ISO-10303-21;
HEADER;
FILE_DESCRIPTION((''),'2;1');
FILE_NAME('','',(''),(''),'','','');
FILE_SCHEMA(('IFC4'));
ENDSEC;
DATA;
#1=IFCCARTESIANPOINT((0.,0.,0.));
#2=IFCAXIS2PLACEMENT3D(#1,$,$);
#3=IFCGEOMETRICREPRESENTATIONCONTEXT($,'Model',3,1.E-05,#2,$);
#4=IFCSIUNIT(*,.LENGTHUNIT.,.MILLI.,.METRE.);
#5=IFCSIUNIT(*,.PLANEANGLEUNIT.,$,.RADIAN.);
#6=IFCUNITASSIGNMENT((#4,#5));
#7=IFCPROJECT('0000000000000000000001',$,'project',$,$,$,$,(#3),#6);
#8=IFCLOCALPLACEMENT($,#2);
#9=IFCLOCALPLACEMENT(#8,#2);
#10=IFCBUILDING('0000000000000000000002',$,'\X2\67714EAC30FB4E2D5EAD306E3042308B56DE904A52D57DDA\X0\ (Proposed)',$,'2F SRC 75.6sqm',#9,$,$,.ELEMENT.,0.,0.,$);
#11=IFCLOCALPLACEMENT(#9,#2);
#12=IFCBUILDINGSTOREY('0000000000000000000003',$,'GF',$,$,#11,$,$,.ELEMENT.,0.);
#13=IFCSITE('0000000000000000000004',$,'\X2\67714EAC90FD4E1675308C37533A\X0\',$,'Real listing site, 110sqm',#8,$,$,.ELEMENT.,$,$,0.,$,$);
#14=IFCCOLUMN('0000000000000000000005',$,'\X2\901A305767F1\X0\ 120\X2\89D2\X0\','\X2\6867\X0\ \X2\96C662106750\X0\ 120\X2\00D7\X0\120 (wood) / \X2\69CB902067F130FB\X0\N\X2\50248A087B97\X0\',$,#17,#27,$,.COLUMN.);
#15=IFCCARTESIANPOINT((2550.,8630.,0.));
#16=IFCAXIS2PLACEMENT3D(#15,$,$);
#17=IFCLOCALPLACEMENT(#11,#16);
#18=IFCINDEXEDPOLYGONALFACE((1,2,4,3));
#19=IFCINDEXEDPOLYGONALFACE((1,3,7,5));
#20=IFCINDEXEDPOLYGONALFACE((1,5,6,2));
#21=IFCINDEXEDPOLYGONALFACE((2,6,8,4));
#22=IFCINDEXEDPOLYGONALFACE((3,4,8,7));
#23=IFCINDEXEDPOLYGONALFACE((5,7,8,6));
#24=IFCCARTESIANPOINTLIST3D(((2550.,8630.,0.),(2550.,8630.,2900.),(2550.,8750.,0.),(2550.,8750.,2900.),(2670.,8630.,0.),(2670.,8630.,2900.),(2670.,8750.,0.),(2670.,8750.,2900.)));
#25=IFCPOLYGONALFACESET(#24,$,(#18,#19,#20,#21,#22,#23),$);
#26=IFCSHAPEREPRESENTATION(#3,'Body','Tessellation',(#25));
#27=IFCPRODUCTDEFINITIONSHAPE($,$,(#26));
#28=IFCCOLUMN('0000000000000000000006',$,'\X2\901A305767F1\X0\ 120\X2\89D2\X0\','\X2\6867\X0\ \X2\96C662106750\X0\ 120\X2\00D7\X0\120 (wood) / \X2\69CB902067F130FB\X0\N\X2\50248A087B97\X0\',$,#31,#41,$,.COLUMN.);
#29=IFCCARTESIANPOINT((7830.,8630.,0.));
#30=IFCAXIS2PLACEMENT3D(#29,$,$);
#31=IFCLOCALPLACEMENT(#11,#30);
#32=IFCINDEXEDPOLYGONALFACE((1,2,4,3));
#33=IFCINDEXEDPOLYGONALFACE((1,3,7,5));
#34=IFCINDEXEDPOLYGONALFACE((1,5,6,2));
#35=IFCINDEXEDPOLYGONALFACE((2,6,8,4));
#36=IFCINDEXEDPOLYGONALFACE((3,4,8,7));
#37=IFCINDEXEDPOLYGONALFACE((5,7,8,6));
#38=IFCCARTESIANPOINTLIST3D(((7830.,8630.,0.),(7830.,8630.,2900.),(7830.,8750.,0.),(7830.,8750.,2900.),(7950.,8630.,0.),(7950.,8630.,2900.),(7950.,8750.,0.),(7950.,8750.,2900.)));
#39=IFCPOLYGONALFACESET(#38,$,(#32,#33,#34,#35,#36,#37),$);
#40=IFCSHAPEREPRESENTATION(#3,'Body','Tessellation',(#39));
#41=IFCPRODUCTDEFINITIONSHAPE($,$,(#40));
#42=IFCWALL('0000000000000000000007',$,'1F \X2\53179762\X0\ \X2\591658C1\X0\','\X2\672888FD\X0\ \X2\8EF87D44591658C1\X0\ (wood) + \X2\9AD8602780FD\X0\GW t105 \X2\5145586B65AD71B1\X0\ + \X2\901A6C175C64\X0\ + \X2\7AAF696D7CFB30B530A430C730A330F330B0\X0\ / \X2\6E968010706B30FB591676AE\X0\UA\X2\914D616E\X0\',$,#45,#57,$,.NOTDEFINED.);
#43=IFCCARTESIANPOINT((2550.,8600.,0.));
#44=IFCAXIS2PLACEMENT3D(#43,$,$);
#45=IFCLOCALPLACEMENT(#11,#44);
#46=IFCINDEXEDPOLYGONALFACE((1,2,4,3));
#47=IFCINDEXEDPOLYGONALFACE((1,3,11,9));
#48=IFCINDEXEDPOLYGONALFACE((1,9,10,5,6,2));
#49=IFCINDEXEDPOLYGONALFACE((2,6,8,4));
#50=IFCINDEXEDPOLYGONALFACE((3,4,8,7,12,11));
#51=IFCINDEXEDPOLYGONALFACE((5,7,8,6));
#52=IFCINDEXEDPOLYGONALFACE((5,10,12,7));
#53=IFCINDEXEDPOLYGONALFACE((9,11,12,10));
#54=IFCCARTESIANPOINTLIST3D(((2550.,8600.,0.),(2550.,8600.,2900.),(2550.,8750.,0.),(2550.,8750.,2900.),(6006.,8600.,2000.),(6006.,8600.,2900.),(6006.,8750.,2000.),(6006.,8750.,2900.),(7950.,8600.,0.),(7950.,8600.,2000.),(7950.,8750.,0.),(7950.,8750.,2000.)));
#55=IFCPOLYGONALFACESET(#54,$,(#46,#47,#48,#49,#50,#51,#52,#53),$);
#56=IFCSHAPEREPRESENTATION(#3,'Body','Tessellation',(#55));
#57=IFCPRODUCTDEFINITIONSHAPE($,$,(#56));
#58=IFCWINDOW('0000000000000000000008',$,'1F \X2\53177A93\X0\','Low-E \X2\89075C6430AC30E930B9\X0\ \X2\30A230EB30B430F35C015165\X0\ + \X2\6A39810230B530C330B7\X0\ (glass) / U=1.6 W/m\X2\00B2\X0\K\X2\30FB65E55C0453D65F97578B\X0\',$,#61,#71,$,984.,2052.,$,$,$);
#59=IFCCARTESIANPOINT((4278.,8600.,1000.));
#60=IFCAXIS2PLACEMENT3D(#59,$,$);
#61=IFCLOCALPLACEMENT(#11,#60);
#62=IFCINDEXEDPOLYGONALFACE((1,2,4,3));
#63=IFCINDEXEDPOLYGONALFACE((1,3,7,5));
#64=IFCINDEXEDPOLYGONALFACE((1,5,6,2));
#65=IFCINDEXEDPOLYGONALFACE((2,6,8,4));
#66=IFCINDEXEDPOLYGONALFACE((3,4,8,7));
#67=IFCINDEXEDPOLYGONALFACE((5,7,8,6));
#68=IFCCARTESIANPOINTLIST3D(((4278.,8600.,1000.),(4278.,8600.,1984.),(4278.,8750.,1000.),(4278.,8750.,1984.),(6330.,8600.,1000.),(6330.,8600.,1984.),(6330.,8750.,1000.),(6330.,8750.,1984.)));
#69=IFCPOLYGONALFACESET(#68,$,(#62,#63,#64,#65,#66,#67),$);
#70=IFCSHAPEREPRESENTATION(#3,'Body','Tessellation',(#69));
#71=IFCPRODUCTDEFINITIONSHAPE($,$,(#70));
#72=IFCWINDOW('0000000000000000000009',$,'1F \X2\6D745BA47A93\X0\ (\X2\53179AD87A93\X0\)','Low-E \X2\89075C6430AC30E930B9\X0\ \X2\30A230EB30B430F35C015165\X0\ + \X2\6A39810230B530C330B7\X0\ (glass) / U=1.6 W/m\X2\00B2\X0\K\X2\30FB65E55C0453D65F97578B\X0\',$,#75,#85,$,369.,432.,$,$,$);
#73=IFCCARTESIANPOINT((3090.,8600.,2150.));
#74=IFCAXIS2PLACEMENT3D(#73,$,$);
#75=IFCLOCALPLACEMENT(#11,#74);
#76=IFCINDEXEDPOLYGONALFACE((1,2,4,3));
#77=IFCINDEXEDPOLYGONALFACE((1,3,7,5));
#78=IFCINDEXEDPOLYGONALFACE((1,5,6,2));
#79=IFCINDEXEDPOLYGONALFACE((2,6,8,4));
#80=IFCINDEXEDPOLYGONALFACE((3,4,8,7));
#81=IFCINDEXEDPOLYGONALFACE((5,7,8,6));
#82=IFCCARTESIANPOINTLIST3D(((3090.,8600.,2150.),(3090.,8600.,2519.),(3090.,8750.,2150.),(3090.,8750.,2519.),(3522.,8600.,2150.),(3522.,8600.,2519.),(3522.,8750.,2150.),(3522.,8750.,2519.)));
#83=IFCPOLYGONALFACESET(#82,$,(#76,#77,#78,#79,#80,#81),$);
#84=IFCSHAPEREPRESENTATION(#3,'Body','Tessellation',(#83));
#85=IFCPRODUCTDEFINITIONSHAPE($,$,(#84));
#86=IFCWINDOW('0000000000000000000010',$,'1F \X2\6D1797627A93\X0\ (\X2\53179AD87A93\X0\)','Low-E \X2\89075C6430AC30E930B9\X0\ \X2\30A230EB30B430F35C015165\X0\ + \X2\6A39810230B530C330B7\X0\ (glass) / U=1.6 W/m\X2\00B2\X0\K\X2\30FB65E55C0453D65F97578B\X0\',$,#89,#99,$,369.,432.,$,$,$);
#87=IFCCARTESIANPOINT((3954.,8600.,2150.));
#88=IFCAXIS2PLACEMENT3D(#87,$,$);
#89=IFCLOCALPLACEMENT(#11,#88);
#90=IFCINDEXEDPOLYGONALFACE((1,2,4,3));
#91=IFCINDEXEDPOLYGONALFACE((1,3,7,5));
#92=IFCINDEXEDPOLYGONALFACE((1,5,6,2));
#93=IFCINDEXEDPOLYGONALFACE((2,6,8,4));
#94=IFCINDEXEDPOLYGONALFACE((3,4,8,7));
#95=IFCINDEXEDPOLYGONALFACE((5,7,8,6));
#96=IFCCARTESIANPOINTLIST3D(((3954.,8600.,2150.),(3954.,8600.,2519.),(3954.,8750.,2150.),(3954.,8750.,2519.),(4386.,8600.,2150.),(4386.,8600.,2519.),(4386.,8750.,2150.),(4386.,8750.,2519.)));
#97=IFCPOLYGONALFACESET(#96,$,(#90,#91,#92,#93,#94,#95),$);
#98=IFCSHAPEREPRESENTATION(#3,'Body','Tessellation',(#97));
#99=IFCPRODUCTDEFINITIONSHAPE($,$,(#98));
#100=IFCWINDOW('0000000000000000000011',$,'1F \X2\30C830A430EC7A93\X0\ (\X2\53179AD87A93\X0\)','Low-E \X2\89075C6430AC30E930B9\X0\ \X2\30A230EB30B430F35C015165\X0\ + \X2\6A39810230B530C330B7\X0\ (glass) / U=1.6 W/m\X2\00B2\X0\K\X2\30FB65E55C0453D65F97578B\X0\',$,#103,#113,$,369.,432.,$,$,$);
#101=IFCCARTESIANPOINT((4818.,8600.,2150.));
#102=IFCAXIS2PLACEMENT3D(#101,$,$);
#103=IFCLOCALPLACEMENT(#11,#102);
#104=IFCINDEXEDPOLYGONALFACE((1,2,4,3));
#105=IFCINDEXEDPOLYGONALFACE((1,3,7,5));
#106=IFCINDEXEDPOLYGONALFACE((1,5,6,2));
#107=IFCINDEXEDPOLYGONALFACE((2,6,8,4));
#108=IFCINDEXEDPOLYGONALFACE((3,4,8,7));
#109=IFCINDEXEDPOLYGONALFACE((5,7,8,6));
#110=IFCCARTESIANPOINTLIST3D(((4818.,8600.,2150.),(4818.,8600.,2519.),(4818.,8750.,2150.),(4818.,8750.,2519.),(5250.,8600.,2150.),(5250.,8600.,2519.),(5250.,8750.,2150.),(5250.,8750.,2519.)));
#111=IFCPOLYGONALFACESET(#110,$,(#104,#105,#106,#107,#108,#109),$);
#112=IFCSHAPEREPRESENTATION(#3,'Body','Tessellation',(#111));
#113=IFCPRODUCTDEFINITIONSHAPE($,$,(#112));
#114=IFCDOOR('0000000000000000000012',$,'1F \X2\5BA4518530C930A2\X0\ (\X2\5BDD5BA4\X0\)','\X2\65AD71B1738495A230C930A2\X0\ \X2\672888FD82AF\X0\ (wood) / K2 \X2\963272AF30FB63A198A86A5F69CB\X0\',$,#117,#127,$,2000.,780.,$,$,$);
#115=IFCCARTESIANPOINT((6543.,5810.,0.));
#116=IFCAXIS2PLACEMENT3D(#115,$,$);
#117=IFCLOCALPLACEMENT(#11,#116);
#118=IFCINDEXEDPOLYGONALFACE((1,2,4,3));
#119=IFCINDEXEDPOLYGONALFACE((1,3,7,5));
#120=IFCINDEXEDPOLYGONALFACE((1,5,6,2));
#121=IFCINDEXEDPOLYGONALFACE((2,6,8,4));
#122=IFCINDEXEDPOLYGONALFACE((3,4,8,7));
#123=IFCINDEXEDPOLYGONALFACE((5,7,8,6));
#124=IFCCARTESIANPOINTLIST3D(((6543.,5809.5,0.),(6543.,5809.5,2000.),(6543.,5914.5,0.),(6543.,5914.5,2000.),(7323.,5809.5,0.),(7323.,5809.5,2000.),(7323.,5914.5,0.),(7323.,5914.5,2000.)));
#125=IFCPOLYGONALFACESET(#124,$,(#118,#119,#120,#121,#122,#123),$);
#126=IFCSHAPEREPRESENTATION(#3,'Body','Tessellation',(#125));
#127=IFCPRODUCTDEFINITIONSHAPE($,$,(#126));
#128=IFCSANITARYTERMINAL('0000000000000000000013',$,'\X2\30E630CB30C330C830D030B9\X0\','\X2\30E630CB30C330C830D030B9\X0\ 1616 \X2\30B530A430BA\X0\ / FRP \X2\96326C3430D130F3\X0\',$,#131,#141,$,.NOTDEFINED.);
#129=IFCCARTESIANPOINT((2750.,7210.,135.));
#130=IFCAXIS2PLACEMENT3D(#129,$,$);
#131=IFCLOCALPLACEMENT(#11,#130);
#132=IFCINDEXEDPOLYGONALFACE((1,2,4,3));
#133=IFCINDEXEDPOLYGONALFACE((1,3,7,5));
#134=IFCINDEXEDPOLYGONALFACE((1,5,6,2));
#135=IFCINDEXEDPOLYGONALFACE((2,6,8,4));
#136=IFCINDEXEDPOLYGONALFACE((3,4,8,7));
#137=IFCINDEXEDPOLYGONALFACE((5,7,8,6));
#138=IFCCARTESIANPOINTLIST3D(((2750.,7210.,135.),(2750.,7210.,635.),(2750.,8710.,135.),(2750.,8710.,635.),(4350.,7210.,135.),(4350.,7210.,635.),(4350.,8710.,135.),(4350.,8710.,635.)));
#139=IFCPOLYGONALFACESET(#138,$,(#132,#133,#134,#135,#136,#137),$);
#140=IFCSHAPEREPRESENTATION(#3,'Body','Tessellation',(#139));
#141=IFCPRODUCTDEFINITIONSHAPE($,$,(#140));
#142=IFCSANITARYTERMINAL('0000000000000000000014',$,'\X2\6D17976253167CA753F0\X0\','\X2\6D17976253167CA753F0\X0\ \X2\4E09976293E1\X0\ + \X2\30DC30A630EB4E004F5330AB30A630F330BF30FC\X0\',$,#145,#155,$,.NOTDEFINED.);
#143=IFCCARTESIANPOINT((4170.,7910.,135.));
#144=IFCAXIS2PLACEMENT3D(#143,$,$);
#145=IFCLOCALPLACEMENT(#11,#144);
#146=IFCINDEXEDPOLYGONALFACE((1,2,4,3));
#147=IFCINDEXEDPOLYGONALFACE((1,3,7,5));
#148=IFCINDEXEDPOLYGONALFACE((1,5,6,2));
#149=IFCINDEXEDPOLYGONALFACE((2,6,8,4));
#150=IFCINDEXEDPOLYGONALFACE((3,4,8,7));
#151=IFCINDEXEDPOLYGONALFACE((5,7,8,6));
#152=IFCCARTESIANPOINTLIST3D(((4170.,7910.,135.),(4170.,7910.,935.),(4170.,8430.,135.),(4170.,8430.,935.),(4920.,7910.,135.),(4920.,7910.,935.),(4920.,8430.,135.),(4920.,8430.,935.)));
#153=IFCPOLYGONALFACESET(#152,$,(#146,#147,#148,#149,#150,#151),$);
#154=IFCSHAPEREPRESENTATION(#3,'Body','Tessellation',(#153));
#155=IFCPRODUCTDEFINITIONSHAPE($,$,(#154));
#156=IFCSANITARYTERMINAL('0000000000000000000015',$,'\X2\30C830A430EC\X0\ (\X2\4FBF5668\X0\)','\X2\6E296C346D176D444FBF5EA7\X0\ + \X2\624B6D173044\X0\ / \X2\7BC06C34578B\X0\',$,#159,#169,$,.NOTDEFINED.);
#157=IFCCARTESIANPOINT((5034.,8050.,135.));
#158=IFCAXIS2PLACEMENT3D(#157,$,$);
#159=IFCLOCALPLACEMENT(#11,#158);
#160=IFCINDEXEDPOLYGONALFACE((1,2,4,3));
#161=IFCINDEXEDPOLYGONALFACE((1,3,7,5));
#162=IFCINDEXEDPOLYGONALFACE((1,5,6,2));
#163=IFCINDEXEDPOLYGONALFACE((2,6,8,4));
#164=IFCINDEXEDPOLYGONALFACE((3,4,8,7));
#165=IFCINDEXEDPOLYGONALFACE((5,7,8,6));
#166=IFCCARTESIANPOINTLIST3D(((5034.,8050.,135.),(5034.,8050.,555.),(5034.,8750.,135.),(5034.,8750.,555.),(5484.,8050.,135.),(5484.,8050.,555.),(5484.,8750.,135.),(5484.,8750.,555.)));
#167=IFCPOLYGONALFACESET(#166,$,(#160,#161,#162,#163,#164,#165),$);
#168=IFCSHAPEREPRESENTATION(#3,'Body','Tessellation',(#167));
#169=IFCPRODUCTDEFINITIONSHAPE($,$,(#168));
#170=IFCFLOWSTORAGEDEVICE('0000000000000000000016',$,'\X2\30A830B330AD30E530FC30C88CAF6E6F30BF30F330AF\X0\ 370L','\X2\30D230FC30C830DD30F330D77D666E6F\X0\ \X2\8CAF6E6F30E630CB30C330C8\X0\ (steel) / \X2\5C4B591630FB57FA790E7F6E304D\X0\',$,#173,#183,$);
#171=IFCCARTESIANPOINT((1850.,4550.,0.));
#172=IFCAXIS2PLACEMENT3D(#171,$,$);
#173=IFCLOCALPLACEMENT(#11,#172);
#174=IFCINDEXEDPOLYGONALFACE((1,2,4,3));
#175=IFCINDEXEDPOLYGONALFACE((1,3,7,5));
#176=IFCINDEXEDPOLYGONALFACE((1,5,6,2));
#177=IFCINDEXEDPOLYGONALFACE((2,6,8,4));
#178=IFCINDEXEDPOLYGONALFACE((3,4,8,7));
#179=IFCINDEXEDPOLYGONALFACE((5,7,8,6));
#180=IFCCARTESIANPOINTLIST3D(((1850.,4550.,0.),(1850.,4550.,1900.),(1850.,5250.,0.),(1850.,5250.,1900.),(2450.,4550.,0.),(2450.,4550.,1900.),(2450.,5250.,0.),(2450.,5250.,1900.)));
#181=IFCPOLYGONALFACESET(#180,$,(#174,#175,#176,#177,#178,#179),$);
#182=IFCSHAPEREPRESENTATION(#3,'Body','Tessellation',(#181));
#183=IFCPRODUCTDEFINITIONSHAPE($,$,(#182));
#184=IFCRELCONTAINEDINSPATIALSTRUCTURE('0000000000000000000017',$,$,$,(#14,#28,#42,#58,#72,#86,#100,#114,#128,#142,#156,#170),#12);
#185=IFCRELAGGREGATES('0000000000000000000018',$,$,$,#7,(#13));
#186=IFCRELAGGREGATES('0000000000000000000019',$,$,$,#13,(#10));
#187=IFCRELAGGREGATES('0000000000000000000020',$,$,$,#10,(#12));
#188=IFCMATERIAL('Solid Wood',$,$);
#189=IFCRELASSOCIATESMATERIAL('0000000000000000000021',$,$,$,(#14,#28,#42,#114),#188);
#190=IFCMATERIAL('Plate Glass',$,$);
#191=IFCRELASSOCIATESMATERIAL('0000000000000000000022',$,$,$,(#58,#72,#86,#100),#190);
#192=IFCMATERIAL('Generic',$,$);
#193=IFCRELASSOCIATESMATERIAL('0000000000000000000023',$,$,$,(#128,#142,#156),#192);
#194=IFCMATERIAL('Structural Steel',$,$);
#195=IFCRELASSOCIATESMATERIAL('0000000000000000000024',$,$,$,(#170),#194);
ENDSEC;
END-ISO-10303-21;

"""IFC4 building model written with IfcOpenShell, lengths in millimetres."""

from ifc_helpers import new_model, si_unit, frame, frame_2d, origin, place, context, project, spatial, rectangle, extrude, material, element, fill, save


model = new_model("IFC4")

# Units and contexts
model_context = context("Model", 3, precision=1e-05, world=origin())
ifc_project = project(units=[si_unit("LENGTHUNIT", "METRE", prefix="MILLI"), si_unit("PLANEANGLEUNIT", "RADIAN")], contexts=[model_context])

# Site, building, storey
site_placement = place(None, origin())
site = spatial("IfcSite", under=ifc_project, at=site_placement, Name="東京都世田谷区", ObjectType="Real listing site, 110sqm", CompositionType="ELEMENT", RefElevation=0.0)
building_placement = place(site_placement, origin())
building = spatial("IfcBuilding", under=site, at=building_placement, Name="東京・中庭のある回遊動線 (Proposed)", ObjectType="2F SRC 75.6sqm", CompositionType="ELEMENT", ElevationOfRefHeight=0.0, ElevationOfTerrain=0.0)
storey_placement = place(building_placement, origin())
storey = spatial("IfcBuildingStorey", under=building, at=storey_placement, Name="GF", CompositionType="ELEMENT", Elevation=0.0)

# Columns
ifc_material_1 = material(Name="Solid Wood")
column_1_placement = place(storey_placement, frame((2550.0, 8630.0, 0.0)))
element("IfcColumn", 1, at=column_1_placement, inside=storey, material=ifc_material_1, Name="通し柱 120角", Description="桧 集成材 120×120 (wood) / 構造柱・N値計算", PredefinedType="COLUMN", context=model_context, shape_type="SweptSolid", body=[
    extrude(rectangle(XDim=120.0, YDim=120.0, at=frame_2d((60.0, 60.0))), frame((2550.0, 8630.0, 0.0)), (0.0, 0.0, 1.0), 2900.0),
])
column_2_placement = place(storey_placement, frame((7830.0, 8630.0, 0.0)))
element("IfcColumn", 2, at=column_2_placement, inside=storey, material=ifc_material_1, Name="通し柱 120角", Description="桧 集成材 120×120 (wood) / 構造柱・N値計算", PredefinedType="COLUMN", context=model_context, shape_type="SweptSolid", body=[
    extrude(rectangle(XDim=120.0, YDim=120.0, at=frame_2d((60.0, 60.0))), frame((7830.0, 8630.0, 0.0)), (0.0, 0.0, 1.0), 2900.0),
])

# Wall, openings, windows
wall_1_placement = place(storey_placement, frame((2550.0, 8600.0, 0.0)))
wall_1 = element("IfcWall", 3, at=wall_1_placement, inside=storey, material=ifc_material_1, Name="1F 北面 外壁", Description="木製 軸組外壁 (wood) + 高性能GW t105 充填断熱 + 通気層 + 窯業系サイディング / 準耐火・外皮UA配慮", PredefinedType="NOTDEFINED", context=model_context, shape_type="SweptSolid", body=[
    extrude(rectangle(XDim=5400.0, YDim=150.0, at=frame_2d((2700.0, 75.0))), frame((2550.0, 8600.0, 0.0)), (0.0, 0.0, 1.0), 2900.0),
])
opening_1_placement = place(storey_placement, frame((4278.0, 8600.0, 1000.0)))
opening_1 = element("IfcOpeningElement", 4, at=opening_1_placement, cuts=wall_1, PredefinedType="NOTDEFINED", context=model_context, shape_type="SweptSolid", body=[
    extrude(rectangle(XDim=2052.0, YDim=150.0, at=frame_2d((1026.0, 75.0))), frame((4278.0, 8600.0, 1000.0)), (0.0, 0.0, 1.0), 984.0),
])
opening_2_placement = place(storey_placement, frame((3090.0, 8600.0, 2150.0)))
opening_2 = element("IfcOpeningElement", 5, at=opening_2_placement, cuts=wall_1, PredefinedType="NOTDEFINED", context=model_context, shape_type="SweptSolid", body=[
    extrude(rectangle(XDim=432.0, YDim=150.0, at=frame_2d((216.0, 75.0))), frame((3090.0, 8600.0, 2150.0)), (0.0, 0.0, 1.0), 369.0),
])
opening_3_placement = place(storey_placement, frame((3954.0, 8600.0, 2150.0)))
opening_3 = element("IfcOpeningElement", 6, at=opening_3_placement, cuts=wall_1, PredefinedType="NOTDEFINED", context=model_context, shape_type="SweptSolid", body=[
    extrude(rectangle(XDim=432.0, YDim=150.0, at=frame_2d((216.0, 75.0))), frame((3954.0, 8600.0, 2150.0)), (0.0, 0.0, 1.0), 369.0),
])
opening_4_placement = place(storey_placement, frame((4818.0, 8600.0, 2150.0)))
opening_4 = element("IfcOpeningElement", 7, at=opening_4_placement, cuts=wall_1, PredefinedType="NOTDEFINED", context=model_context, shape_type="SweptSolid", body=[
    extrude(rectangle(XDim=432.0, YDim=150.0, at=frame_2d((216.0, 75.0))), frame((4818.0, 8600.0, 2150.0)), (0.0, 0.0, 1.0), 369.0),
])
ifc_material_2 = material(Name="Plate Glass")
window_1_placement = place(storey_placement, frame((4278.0, 8600.0, 1000.0)))
window_1 = element("IfcWindow", 8, at=window_1_placement, inside=storey, material=ifc_material_2, Name="1F 北窓", Description="Low-E 複層ガラス アルゴン封入 + 樹脂サッシ (glass) / U=1.6 W/m²K・日射取得型", OverallHeight=984.0, OverallWidth=2052.0, context=model_context, shape_type="SweptSolid", body=[
    extrude(rectangle(XDim=2052.0, YDim=150.0, at=frame_2d((1026.0, 75.0))), frame((4278.0, 8600.0, 1000.0)), (0.0, 0.0, 1.0), 984.0),
])
fill(opening_1, window_1)
window_2_placement = place(storey_placement, frame((3090.0, 8600.0, 2150.0)))
window_2 = element("IfcWindow", 9, at=window_2_placement, inside=storey, material=ifc_material_2, Name="1F 浴室窓 (北高窓)", Description="Low-E 複層ガラス アルゴン封入 + 樹脂サッシ (glass) / U=1.6 W/m²K・日射取得型", OverallHeight=369.0, OverallWidth=432.0, context=model_context, shape_type="SweptSolid", body=[
    extrude(rectangle(XDim=432.0, YDim=150.0, at=frame_2d((216.0, 75.0))), frame((3090.0, 8600.0, 2150.0)), (0.0, 0.0, 1.0), 369.0),
])
fill(opening_2, window_2)
window_3_placement = place(storey_placement, frame((3954.0, 8600.0, 2150.0)))
window_3 = element("IfcWindow", 10, at=window_3_placement, inside=storey, material=ifc_material_2, Name="1F 洗面窓 (北高窓)", Description="Low-E 複層ガラス アルゴン封入 + 樹脂サッシ (glass) / U=1.6 W/m²K・日射取得型", OverallHeight=369.0, OverallWidth=432.0, context=model_context, shape_type="SweptSolid", body=[
    extrude(rectangle(XDim=432.0, YDim=150.0, at=frame_2d((216.0, 75.0))), frame((3954.0, 8600.0, 2150.0)), (0.0, 0.0, 1.0), 369.0),
])
fill(opening_3, window_3)
window_4_placement = place(storey_placement, frame((4818.0, 8600.0, 2150.0)))
window_4 = element("IfcWindow", 11, at=window_4_placement, inside=storey, material=ifc_material_2, Name="1F トイレ窓 (北高窓)", Description="Low-E 複層ガラス アルゴン封入 + 樹脂サッシ (glass) / U=1.6 W/m²K・日射取得型", OverallHeight=369.0, OverallWidth=432.0, context=model_context, shape_type="SweptSolid", body=[
    extrude(rectangle(XDim=432.0, YDim=150.0, at=frame_2d((216.0, 75.0))), frame((4818.0, 8600.0, 2150.0)), (0.0, 0.0, 1.0), 369.0),
])
fill(opening_4, window_4)

# Door
door_1_placement = place(storey_placement, frame((6543.0, 5810.0, 0.0)))
element("IfcDoor", 12, at=door_1_placement, inside=storey, material=ifc_material_1, Name="1F 室内ドア (寝室)", Description="断熱玄関ドア 木製芯 (wood) / K2 防犯・採風機構", OverallHeight=2000.0, OverallWidth=780.0, context=model_context, shape_type="SweptSolid", body=[
    extrude(rectangle(XDim=780.0, YDim=105.0, at=frame_2d((390.0, 52.0))), frame((6543.0, 5810.0, 0.0)), (0.0, 0.0, 1.0), 2000.0),
])

# Sanitary terminals
ifc_material_3 = material(Name="Generic")
sanitary_terminal_1_placement = place(storey_placement, frame((2750.0, 7210.0, 135.0)))
element("IfcSanitaryTerminal", 13, at=sanitary_terminal_1_placement, inside=storey, material=ifc_material_3, Name="ユニットバス", Description="ユニットバス 1616 サイズ / FRP 防水パン", PredefinedType="NOTDEFINED", context=model_context, shape_type="SweptSolid", body=[
    extrude(rectangle(XDim=1600.0, YDim=1500.0, at=frame_2d((800.0, 750.0))), frame((2750.0, 7210.0, 135.0)), (0.0, 0.0, 1.0), 500.0),
])
sanitary_terminal_2_placement = place(storey_placement, frame((4170.0, 7910.0, 135.0)))
element("IfcSanitaryTerminal", 14, at=sanitary_terminal_2_placement, inside=storey, material=ifc_material_3, Name="洗面化粧台", Description="洗面化粧台 三面鏡 + ボウル一体カウンター", PredefinedType="NOTDEFINED", context=model_context, shape_type="SweptSolid", body=[
    extrude(rectangle(XDim=750.0, YDim=520.0, at=frame_2d((375.0, 260.0))), frame((4170.0, 7910.0, 135.0)), (0.0, 0.0, 1.0), 800.0),
])
sanitary_terminal_3_placement = place(storey_placement, frame((5034.0, 8050.0, 135.0)))
element("IfcSanitaryTerminal", 15, at=sanitary_terminal_3_placement, inside=storey, material=ifc_material_3, Name="トイレ (便器)", Description="温水洗浄便座 + 手洗い / 節水型", PredefinedType="NOTDEFINED", context=model_context, shape_type="SweptSolid", body=[
    extrude(rectangle(XDim=450.0, YDim=700.0, at=frame_2d((225.0, 350.0))), frame((5034.0, 8050.0, 135.0)), (0.0, 0.0, 1.0), 420.0),
])

# Flow storage device
ifc_material_4 = material(Name="Structural Steel")
flow_storage_device_placement = place(storey_placement, frame((1850.0, 4550.0, 0.0)))
element("IfcFlowStorageDevice", 16, at=flow_storage_device_placement, inside=storey, material=ifc_material_4, Name="エコキュート貯湯タンク 370L", Description="ヒートポンプ給湯 貯湯ユニット (steel) / 屋外・基礎置き", context=model_context, shape_type="SweptSolid", body=[
    extrude(rectangle(XDim=600.0, YDim=700.0, at=frame_2d((300.0, 350.0))), frame((1850.0, 4550.0, 0.0)), (0.0, 0.0, 1.0), 1900.0),
])

save(model, "model.ifc")
